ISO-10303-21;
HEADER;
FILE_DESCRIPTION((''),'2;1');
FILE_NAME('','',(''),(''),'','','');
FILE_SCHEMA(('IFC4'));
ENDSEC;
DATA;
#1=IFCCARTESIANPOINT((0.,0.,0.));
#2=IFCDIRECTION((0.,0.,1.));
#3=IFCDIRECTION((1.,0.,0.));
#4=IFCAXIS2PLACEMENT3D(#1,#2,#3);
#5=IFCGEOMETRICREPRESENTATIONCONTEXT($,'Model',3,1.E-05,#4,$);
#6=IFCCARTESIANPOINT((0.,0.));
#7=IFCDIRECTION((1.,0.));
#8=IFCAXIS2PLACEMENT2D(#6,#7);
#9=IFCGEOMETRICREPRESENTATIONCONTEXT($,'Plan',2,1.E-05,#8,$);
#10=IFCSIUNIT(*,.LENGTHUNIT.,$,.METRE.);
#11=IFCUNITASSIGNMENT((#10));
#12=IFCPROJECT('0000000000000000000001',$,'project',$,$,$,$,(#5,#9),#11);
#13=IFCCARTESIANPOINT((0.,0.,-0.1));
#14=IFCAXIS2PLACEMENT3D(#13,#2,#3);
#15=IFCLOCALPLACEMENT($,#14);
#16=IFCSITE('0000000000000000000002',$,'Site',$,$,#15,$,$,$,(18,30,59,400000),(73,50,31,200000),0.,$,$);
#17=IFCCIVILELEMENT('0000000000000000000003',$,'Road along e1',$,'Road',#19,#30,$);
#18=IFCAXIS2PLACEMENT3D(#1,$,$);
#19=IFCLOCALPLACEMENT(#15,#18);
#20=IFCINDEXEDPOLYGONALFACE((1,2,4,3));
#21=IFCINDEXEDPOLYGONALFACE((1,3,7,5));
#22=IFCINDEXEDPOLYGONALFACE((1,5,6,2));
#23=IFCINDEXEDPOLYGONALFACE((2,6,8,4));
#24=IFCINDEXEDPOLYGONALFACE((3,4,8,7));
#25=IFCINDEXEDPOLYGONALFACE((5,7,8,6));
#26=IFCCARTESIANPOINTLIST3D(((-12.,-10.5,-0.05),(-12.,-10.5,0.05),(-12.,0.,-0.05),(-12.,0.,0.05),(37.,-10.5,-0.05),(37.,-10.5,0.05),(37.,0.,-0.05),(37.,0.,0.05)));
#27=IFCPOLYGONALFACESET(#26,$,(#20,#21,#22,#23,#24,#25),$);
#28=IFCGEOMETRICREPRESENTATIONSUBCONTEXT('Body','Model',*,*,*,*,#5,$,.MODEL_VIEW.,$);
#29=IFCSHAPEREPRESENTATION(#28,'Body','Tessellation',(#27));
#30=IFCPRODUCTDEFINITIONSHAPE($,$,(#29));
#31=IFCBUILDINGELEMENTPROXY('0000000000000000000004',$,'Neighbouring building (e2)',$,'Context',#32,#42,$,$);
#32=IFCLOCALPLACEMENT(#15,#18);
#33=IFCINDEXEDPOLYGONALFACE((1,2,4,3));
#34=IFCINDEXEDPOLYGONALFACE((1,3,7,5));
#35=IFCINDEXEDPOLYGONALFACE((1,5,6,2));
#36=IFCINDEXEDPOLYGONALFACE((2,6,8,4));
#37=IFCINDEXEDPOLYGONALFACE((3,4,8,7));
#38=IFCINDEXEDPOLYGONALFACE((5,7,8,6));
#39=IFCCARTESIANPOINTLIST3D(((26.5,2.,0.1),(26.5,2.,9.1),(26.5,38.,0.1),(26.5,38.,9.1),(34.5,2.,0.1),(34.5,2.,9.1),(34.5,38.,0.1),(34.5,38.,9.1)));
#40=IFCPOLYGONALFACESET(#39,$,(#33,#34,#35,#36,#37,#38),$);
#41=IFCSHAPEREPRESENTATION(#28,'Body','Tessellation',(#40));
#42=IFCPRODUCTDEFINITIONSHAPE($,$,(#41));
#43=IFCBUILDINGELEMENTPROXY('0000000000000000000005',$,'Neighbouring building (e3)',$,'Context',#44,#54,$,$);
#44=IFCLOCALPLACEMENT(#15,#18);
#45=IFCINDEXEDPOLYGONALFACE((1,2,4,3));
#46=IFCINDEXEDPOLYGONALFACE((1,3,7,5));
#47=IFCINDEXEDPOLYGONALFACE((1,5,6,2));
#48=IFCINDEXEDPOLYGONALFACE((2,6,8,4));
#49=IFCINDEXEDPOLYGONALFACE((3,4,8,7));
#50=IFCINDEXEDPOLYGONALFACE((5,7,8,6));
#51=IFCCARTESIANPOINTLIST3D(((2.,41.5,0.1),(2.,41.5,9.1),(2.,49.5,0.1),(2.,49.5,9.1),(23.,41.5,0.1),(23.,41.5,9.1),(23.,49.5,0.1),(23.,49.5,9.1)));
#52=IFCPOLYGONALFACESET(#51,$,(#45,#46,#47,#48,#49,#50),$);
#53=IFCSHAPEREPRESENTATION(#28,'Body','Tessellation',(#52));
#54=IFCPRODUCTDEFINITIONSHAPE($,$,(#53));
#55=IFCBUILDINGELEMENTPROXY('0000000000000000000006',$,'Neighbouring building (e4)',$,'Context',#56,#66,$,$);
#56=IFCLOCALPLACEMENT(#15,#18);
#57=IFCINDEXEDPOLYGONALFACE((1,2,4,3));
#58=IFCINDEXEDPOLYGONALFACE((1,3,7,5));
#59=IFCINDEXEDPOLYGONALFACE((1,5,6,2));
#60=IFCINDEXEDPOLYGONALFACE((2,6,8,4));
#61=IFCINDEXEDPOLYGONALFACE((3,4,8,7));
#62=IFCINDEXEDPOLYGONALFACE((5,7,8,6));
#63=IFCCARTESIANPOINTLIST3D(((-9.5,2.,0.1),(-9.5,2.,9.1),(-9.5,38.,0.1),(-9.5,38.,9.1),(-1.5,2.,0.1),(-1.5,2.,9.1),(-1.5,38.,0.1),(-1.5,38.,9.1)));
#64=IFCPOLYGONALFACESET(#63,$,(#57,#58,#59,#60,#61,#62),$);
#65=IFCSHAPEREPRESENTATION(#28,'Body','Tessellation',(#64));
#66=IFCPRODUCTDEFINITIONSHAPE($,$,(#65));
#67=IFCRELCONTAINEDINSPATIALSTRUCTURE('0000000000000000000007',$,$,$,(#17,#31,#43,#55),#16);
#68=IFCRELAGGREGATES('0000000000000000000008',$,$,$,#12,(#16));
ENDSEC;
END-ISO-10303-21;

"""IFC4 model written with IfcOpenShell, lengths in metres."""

from ifc_helpers import new_model, si_unit, frame, origin_with_axes, origin_2d_with_axis, place, context, subcontext, project, spatial, line, indexed_curve, outline, extrude, element, save


model = new_model("IFC4")

# Units and contexts
model_context = context("Model", 3, precision=1e-05, world=origin_with_axes())
plan_context = context("Plan", 2, precision=1e-05, world=origin_2d_with_axis())
body_context = subcontext(model_context, "Body", "Model", "MODEL_VIEW")
ifc_project = project(units=[si_unit("LENGTHUNIT", "METRE")], contexts=[model_context, plan_context])

# Site
site_placement = place(None, frame((0.0, 0.0, -0.1), z_axis=(0.0, 0.0, 1.0), x_axis=(1.0, 0.0, 0.0)))
site = spatial("IfcSite", under=ifc_project, at=site_placement, Name="Site", RefLatitude=(18, 30, 59, 400000), RefLongitude=(73, 50, 31, 200000), RefElevation=0.0)

# Civil element
civil_element_placement = place(site_placement, frame((0.0, 0.0, -0.05), z_axis=(0.0, 0.0, 1.0), x_axis=(1.0, 0.0, 0.0)))
element("IfcCivilElement", 1, at=civil_element_placement, inside=site, Name="Road along e1", ObjectType="Road", context=body_context, shape_type="SweptSolid", body=[
    extrude(outline(indexed_curve([(-12.0, 0.0), (37.0, 0.0), (37.0, -10.5), (-12.0, -10.5)], segments=[line(1, 2, 3, 4, 1)])), origin_with_axes(), (0.0, 0.0, 1.0), 0.1),
])

# Building element proxies
proxy_1_placement = place(site_placement, frame((0.0, 0.0, 0.1), z_axis=(0.0, 0.0, 1.0), x_axis=(1.0, 0.0, 0.0)))
element("IfcBuildingElementProxy", 2, at=proxy_1_placement, inside=site, Name="Neighbouring building (e2)", ObjectType="Context", context=body_context, shape_type="SweptSolid", body=[
    extrude(outline(indexed_curve([(26.5, 2.0), (26.5, 38.0), (34.5, 38.0), (34.5, 2.0)], segments=[line(1, 2, 3, 4, 1)])), origin_with_axes(), (0.0, 0.0, 1.0), 9.0),
])
proxy_2_placement = place(site_placement, frame((0.0, 0.0, 0.1), z_axis=(0.0, 0.0, 1.0), x_axis=(1.0, 0.0, 0.0)))
element("IfcBuildingElementProxy", 3, at=proxy_2_placement, inside=site, Name="Neighbouring building (e3)", ObjectType="Context", context=body_context, shape_type="SweptSolid", body=[
    extrude(outline(indexed_curve([(23.0, 41.5), (2.0, 41.5), (2.0, 49.5), (23.0, 49.5)], segments=[line(1, 2, 3, 4, 1)])), origin_with_axes(), (0.0, 0.0, 1.0), 9.0),
])
proxy_3_placement = place(site_placement, frame((0.0, 0.0, 0.1), z_axis=(0.0, 0.0, 1.0), x_axis=(1.0, 0.0, 0.0)))
element("IfcBuildingElementProxy", 4, at=proxy_3_placement, inside=site, Name="Neighbouring building (e4)", ObjectType="Context", context=body_context, shape_type="SweptSolid", body=[
    extrude(outline(indexed_curve([(-1.5, 38.0), (-1.5, 2.0), (-9.5, 2.0), (-9.5, 38.0)], segments=[line(1, 2, 3, 4, 1)])), origin_with_axes(), (0.0, 0.0, 1.0), 9.0),
])

save(model, "model.ifc")
